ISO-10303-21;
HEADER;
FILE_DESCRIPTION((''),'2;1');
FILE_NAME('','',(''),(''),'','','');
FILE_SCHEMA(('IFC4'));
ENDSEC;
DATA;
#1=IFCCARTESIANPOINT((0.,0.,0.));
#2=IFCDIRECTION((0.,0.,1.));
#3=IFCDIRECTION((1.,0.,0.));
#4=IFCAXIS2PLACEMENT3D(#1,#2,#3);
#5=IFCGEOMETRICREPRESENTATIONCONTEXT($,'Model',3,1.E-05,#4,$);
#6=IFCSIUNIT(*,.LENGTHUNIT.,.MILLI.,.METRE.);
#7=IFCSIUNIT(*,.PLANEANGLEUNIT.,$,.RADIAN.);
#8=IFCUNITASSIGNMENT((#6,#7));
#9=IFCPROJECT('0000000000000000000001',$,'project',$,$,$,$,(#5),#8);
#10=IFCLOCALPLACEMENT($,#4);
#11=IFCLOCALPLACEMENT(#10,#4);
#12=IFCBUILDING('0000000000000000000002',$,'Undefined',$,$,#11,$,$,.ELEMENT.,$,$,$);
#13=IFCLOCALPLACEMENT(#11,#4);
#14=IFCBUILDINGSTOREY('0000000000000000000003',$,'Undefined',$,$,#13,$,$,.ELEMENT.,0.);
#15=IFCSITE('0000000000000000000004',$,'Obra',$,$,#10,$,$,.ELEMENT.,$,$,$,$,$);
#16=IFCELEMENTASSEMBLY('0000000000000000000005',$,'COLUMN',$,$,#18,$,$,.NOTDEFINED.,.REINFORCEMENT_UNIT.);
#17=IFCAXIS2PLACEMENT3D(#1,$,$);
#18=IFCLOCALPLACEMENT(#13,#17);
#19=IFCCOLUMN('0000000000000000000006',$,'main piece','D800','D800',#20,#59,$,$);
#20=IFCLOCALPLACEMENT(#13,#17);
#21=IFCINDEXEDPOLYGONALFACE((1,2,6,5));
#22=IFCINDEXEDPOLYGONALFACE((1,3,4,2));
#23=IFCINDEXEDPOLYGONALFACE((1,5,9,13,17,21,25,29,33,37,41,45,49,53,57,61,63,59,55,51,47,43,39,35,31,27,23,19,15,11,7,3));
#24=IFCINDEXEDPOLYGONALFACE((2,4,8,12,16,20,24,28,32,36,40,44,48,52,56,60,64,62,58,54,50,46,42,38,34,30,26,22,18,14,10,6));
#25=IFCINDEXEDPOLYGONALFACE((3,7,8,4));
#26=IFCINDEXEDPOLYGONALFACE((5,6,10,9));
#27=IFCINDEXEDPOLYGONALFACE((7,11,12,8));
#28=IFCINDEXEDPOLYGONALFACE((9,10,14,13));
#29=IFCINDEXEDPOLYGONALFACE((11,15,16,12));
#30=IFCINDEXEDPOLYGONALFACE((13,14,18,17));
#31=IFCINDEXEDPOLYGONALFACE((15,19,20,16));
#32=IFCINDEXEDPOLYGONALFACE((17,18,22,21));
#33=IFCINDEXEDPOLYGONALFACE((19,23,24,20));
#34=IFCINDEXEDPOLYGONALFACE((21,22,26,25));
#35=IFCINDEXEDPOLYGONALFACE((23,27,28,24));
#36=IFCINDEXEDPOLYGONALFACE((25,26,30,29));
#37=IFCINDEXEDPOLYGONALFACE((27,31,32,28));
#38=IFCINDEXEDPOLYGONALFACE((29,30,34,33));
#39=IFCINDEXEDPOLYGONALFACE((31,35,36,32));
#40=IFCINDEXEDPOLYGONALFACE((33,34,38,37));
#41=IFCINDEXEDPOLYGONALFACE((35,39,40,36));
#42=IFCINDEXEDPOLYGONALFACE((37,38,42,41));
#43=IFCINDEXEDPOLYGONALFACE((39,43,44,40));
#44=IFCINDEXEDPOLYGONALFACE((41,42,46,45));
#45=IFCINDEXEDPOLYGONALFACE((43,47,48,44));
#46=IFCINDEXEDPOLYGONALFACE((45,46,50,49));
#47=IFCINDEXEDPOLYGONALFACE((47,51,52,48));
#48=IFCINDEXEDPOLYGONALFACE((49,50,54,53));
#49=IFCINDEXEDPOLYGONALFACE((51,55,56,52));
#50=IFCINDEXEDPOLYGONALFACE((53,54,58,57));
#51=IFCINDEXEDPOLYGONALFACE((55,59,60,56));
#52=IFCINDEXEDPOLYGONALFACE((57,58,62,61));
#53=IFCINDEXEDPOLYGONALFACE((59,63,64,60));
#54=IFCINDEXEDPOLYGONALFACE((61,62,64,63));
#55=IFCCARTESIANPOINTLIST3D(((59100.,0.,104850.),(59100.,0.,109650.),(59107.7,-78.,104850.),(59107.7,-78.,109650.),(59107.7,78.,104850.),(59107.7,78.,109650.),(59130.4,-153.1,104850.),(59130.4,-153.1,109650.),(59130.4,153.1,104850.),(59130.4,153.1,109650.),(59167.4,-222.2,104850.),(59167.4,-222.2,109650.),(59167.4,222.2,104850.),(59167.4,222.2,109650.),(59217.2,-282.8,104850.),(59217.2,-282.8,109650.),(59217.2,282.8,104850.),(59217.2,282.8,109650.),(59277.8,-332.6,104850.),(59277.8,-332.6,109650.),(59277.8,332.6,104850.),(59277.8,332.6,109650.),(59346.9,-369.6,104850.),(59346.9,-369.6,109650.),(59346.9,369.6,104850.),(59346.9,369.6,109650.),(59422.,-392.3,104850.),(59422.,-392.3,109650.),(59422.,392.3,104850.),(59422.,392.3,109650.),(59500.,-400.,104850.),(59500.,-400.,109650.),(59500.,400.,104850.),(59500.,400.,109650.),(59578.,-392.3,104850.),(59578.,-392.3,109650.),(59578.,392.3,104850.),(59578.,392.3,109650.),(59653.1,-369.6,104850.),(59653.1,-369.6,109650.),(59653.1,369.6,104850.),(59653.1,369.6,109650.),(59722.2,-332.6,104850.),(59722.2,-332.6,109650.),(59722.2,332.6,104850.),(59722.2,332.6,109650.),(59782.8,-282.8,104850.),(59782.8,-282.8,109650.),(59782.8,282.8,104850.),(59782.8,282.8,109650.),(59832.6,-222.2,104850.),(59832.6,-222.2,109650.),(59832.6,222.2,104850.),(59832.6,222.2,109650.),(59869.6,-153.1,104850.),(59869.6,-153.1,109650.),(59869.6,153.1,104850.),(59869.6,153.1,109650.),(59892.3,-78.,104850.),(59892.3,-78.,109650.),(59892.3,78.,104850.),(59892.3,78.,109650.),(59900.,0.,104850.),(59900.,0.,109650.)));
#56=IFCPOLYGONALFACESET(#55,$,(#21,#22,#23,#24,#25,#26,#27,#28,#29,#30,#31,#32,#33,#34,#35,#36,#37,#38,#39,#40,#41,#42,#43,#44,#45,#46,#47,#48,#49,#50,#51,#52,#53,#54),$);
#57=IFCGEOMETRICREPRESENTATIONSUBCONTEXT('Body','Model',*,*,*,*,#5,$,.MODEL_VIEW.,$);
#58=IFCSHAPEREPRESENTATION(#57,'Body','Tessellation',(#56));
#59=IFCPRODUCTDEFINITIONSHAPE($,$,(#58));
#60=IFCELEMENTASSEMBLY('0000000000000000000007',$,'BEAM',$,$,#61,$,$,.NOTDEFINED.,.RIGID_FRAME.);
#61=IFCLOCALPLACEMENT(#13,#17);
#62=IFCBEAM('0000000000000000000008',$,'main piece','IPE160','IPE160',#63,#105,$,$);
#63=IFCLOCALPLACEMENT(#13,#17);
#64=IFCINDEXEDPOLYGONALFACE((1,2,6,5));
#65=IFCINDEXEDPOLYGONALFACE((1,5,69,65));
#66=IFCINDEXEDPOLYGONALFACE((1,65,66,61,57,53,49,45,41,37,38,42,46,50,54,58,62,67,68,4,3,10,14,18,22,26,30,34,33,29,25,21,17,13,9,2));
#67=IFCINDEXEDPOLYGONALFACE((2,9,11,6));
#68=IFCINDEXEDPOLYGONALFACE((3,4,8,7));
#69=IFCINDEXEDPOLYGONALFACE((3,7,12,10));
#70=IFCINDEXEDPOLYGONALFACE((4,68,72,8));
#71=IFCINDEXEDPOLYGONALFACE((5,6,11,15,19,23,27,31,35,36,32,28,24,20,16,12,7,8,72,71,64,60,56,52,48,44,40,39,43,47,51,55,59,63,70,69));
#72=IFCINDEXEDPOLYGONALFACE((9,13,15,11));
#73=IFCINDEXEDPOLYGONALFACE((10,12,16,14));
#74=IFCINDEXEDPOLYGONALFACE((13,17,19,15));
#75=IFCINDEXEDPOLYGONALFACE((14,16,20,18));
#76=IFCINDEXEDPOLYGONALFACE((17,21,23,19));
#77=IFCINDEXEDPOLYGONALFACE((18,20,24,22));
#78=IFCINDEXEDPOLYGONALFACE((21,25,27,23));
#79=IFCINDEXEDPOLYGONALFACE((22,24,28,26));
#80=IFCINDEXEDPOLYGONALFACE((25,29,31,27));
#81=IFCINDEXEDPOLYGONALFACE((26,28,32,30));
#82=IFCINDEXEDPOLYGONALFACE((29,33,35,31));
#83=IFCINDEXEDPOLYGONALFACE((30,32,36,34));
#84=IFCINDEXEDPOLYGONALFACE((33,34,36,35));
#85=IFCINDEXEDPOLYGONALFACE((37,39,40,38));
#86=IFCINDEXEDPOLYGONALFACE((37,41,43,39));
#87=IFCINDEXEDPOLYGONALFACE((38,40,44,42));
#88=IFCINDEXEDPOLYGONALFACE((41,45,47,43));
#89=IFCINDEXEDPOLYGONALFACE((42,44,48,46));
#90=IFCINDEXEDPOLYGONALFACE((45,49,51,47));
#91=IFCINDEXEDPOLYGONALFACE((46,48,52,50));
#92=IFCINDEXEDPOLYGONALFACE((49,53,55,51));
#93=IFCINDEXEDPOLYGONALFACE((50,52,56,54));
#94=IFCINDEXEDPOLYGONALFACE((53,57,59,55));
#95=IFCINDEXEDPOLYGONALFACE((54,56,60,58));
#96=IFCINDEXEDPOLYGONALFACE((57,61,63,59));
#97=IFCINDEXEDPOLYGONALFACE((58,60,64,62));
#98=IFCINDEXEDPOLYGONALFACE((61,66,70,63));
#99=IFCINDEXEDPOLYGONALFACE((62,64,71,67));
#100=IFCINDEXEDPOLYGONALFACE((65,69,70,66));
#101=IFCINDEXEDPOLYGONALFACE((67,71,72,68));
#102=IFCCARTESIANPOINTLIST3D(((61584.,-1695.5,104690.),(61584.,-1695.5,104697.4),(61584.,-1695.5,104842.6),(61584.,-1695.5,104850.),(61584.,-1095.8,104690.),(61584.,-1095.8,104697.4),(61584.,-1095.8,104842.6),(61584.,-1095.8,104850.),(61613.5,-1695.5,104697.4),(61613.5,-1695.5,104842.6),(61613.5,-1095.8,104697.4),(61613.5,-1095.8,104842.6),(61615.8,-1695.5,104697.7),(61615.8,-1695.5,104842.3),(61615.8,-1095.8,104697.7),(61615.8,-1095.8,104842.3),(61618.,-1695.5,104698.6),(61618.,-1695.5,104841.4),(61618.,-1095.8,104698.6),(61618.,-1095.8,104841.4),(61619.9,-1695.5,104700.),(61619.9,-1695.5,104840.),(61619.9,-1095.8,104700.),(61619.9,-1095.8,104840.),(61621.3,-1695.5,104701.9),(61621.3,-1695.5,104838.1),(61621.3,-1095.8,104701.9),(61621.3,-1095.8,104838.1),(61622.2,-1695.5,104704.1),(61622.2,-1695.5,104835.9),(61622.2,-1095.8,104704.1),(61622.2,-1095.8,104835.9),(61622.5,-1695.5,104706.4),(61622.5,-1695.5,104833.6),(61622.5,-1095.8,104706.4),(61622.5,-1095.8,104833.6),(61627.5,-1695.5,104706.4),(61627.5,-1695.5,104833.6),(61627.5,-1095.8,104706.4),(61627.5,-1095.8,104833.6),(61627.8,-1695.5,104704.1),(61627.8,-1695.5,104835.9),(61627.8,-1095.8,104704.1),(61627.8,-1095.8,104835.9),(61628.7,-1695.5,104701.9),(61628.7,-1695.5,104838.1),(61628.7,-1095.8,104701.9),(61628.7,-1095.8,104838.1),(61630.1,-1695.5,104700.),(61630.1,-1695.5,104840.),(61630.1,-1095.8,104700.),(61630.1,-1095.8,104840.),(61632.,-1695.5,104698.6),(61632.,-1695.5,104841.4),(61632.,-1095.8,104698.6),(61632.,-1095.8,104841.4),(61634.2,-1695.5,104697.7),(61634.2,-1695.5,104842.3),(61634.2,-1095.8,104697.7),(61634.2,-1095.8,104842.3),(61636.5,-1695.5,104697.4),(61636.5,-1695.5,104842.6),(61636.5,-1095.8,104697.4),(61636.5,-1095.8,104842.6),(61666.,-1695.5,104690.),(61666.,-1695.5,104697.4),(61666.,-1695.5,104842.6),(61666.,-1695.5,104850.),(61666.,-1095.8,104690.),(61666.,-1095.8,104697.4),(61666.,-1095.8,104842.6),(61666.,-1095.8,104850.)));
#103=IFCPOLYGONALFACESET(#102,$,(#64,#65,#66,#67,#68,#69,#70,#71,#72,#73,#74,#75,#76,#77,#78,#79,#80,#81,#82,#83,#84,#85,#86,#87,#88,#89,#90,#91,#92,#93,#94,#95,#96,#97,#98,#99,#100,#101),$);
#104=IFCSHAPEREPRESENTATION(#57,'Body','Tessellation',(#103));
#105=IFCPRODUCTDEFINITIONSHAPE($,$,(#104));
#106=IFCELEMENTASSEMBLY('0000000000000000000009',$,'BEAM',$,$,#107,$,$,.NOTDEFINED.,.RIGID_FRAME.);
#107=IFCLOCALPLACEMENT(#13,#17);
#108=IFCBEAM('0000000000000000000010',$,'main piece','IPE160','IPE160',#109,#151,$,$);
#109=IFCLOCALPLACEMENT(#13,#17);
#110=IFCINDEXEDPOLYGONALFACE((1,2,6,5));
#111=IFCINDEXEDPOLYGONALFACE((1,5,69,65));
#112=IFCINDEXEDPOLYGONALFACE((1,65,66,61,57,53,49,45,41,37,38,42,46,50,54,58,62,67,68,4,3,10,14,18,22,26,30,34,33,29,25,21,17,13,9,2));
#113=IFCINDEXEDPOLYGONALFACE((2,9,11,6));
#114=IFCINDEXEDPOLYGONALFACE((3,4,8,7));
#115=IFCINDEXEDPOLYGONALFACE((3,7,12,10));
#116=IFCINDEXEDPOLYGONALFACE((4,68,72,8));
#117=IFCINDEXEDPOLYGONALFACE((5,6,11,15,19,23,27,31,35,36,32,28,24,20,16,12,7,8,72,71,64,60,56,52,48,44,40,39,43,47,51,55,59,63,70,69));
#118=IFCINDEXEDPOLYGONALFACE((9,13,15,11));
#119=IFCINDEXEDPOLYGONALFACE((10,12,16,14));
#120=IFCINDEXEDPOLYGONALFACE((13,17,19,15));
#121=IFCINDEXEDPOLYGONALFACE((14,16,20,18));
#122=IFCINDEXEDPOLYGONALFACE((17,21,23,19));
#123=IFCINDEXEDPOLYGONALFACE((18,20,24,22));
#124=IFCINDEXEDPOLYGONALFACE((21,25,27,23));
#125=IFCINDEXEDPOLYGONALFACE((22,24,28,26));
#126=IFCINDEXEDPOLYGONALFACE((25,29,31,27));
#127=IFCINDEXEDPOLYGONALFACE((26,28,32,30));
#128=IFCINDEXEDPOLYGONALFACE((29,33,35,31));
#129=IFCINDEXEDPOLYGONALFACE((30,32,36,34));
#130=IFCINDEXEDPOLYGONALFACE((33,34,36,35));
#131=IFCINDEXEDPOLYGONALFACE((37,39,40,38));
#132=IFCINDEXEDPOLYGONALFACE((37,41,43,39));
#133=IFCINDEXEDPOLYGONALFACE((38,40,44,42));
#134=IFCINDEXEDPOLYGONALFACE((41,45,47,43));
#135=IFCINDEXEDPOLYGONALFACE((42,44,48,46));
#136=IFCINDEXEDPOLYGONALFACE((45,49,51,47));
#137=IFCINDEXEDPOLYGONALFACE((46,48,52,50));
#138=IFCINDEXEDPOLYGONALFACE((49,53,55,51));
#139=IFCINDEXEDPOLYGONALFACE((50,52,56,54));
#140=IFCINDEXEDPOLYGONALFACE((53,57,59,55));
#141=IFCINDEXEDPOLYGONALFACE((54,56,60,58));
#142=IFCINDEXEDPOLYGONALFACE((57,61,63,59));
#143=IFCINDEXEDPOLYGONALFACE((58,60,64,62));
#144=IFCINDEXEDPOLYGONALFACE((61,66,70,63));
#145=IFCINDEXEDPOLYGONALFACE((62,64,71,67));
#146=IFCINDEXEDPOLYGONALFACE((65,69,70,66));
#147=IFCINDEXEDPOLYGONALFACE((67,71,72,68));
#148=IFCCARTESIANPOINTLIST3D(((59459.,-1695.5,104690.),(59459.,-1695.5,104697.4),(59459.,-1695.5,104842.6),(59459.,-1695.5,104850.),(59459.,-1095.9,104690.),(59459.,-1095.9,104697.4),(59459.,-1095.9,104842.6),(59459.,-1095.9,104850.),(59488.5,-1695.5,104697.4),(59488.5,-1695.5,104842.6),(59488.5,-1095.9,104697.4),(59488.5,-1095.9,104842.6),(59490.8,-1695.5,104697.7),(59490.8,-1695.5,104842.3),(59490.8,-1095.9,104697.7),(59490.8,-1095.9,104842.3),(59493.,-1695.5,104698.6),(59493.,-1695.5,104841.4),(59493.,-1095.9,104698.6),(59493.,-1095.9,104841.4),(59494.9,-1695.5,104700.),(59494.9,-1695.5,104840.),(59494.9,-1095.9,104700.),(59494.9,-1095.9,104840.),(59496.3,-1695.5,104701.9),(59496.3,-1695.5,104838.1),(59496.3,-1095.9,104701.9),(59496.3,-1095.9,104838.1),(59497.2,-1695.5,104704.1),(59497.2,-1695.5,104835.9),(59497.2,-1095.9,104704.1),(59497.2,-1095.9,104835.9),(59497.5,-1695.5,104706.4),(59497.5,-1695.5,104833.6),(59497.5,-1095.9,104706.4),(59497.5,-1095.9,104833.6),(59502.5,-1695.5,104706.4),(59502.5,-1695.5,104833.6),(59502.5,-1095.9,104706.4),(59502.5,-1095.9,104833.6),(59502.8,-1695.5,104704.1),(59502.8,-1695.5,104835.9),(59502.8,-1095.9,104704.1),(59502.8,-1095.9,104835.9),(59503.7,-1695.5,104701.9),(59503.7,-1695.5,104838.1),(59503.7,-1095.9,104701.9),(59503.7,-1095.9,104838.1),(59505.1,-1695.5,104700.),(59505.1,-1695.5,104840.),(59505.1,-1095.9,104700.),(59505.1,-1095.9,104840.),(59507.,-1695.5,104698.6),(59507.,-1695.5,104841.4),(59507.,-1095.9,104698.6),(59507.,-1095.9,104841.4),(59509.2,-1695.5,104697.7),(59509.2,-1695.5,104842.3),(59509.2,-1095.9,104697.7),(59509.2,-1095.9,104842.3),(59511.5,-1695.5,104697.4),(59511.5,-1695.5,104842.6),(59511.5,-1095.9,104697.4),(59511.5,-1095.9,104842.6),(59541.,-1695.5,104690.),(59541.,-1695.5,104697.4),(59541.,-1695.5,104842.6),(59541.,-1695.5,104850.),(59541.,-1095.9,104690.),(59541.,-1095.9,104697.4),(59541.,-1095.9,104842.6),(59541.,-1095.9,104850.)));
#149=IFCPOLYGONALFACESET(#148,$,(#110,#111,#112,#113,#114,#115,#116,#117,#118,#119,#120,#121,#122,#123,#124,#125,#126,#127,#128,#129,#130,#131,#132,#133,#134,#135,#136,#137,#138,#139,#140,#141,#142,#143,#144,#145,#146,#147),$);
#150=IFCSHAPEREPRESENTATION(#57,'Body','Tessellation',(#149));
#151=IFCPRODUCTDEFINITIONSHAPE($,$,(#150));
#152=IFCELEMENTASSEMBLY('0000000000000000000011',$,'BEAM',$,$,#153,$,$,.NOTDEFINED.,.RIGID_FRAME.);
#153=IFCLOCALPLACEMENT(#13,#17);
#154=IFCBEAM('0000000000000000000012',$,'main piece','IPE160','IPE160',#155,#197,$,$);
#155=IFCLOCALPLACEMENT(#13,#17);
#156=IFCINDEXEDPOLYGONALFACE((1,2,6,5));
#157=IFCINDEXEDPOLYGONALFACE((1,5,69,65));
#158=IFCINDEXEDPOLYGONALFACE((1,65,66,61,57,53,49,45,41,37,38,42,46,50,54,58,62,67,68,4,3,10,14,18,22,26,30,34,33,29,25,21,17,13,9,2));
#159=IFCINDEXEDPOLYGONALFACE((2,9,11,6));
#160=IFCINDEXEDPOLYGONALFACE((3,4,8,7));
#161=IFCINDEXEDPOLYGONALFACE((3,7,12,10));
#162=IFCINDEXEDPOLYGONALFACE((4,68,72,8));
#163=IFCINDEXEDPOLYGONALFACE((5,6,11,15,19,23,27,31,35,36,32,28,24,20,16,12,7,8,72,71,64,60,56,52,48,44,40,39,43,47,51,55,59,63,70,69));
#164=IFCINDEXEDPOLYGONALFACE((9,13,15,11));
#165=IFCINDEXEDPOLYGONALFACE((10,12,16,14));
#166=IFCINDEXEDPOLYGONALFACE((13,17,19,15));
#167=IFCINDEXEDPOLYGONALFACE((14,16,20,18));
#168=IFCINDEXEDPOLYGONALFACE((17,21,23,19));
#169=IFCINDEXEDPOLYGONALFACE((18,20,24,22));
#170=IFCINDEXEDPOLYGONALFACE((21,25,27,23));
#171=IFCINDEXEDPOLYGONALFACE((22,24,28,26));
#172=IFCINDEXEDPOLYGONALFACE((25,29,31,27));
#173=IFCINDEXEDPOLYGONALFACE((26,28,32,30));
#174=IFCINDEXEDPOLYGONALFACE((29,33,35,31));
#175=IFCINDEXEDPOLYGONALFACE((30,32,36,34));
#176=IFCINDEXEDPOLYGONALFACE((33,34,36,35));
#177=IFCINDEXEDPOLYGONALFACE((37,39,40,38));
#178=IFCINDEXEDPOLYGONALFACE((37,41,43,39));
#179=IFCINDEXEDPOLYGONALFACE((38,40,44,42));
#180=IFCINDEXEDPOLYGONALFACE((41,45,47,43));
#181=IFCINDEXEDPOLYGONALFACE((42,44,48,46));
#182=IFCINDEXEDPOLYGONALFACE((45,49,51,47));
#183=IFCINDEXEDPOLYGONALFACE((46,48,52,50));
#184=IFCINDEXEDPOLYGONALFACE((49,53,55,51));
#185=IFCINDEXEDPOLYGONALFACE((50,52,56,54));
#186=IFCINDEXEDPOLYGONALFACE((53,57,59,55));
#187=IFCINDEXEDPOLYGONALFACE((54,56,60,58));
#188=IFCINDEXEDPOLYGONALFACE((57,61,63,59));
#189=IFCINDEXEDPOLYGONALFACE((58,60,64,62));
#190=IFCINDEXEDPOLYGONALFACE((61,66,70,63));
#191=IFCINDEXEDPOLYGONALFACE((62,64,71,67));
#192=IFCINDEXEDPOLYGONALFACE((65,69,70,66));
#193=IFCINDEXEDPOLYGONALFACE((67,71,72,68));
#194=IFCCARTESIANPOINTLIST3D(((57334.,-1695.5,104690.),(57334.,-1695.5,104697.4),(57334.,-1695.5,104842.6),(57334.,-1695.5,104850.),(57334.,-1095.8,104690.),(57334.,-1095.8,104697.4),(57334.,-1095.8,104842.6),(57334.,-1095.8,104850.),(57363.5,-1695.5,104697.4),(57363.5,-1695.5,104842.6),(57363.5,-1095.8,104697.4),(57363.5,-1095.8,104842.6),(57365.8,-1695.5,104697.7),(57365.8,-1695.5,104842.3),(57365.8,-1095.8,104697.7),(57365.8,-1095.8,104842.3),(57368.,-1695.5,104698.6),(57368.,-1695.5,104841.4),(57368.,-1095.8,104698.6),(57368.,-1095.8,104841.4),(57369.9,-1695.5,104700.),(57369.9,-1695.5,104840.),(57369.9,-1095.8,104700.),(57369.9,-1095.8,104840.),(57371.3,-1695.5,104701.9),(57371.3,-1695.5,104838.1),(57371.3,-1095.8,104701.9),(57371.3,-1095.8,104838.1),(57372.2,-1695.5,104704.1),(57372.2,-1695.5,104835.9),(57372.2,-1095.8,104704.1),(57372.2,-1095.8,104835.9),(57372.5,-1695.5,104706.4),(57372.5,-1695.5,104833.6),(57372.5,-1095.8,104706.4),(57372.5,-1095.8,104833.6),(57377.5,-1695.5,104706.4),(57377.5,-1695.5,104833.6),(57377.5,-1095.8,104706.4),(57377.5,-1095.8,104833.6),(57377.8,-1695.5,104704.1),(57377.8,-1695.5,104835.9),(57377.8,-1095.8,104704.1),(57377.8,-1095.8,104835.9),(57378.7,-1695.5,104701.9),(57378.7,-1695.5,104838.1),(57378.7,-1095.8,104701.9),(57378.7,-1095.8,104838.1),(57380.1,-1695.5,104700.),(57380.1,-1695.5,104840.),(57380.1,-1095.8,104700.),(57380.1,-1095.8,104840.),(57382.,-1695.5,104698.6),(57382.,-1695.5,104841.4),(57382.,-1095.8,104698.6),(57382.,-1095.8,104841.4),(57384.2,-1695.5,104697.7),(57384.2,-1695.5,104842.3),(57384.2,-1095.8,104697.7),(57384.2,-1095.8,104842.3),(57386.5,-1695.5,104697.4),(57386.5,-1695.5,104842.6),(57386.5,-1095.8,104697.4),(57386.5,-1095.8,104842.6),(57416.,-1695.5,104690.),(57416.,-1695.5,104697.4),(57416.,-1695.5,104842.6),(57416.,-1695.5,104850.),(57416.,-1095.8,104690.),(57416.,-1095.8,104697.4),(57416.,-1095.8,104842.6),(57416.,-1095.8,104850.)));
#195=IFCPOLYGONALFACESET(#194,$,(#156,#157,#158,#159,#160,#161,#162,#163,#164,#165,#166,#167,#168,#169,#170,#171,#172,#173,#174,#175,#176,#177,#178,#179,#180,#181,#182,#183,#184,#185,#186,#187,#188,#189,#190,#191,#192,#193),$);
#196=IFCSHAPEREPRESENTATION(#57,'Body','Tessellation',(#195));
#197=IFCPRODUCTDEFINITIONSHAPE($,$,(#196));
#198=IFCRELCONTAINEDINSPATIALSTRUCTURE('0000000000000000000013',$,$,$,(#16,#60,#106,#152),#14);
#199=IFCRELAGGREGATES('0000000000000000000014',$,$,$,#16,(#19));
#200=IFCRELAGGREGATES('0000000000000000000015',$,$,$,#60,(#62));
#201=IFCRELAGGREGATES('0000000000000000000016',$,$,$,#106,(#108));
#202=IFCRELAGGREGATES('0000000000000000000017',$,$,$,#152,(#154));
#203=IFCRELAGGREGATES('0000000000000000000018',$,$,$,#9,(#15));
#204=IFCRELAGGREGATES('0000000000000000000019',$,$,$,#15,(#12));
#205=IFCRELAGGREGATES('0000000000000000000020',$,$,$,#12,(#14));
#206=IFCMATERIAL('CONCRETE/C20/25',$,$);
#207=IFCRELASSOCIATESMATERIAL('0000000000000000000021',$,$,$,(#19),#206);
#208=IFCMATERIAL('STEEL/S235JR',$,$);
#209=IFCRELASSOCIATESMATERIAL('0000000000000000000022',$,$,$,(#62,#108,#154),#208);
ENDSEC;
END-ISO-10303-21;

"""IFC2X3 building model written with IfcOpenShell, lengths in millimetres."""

from ifc_helpers import new_model, si_unit, frame, origin_with_axes, origin_2d_with_axis, place, context, subcontext, project, spatial, circle, i_section, extrude, material, element, aggregate, save


model = new_model("IFC2X3")

# Units and contexts
model_context = context("Model", 3, precision=1e-05, world=origin_with_axes())
body_context = subcontext(model_context, "Body", "Model", "MODEL_VIEW")
ifc_project = project(units=[si_unit("LENGTHUNIT", "METRE", prefix="MILLI"), si_unit("PLANEANGLEUNIT", "RADIAN")], contexts=[model_context])

# Site, building, storey
site_placement = place(None, origin_with_axes())
site = spatial("IfcSite", under=ifc_project, at=site_placement, Name="Obra", CompositionType="ELEMENT")
building_placement = place(site_placement, origin_with_axes())
building = spatial("IfcBuilding", under=site, at=building_placement, Name="Undefined", CompositionType="ELEMENT")
storey_placement = place(building_placement, origin_with_axes())
storey = spatial("IfcBuildingStorey", under=building, at=storey_placement, Name="Undefined", CompositionType="ELEMENT", Elevation=0.0)

# Element assembly, column
assembly_1_placement = place(storey_placement, origin_with_axes())
assembly_1 = element("IfcElementAssembly", 1, at=assembly_1_placement, inside=storey, Name="COLUMN", AssemblyPlace="NOTDEFINED", PredefinedType="REINFORCEMENT_UNIT")
ifc_material_1 = material(Name="CONCRETE/C20/25")
column_placement = place(assembly_1_placement, frame((59500.0, 0.0, 104850.0), z_axis=(0.0, 0.0, 1.0), x_axis=(0.0, 1.0, 0.0)))
column = element("IfcColumn", 2, at=column_placement, material=ifc_material_1, Name="main piece", Description="D800", ObjectType="D800", context=body_context, shape_type="SweptSolid", body=[
    extrude(circle(Radius=400.0, at=origin_2d_with_axis()), frame((0.0, 0.0, 4800.0), z_axis=(0.0, 0.0, -1.0), x_axis=(0.0, 1.0, 0.0)), (0.0, 0.0, 1.0), 4800.0),
])
aggregate(assembly_1, [column])

# Element assemblies, beams
assembly_2_placement = place(storey_placement, origin_with_axes())
assembly_2 = element("IfcElementAssembly", 3, at=assembly_2_placement, inside=storey, Name="BEAM", AssemblyPlace="NOTDEFINED", PredefinedType="RIGID_FRAME")
ifc_material_2 = material(Name="STEEL/S235JR")
beam_1_placement = place(assembly_2_placement, frame((61625.0, -1095.8, 104770.0), z_axis=(0.0, 0.0, 1.0), x_axis=(0.0, -1.0, 0.0)))
beam_1 = element("IfcBeam", 4, at=beam_1_placement, material=ifc_material_2, Name="main piece", Description="IPE160", ObjectType="IPE160", context=body_context, shape_type="SweptSolid", body=[
    extrude(i_section(OverallWidth=82.0, OverallDepth=160.0, WebThickness=5.0, FlangeThickness=7.4, FilletRadius=9.0, at=origin_2d_with_axis()), frame((599.7, 0.0, 0.0), z_axis=(-1.0, 0.0, 0.0), x_axis=(0.0, -1.0, 0.0)), (0.0, 0.0, 1.0), 599.7),
])
aggregate(assembly_2, [beam_1])
assembly_3_placement = place(storey_placement, origin_with_axes())
assembly_3 = element("IfcElementAssembly", 5, at=assembly_3_placement, inside=storey, Name="BEAM", AssemblyPlace="NOTDEFINED", PredefinedType="RIGID_FRAME")
beam_2_placement = place(assembly_3_placement, frame((59500.0, -1095.9, 104770.0), z_axis=(0.0, 0.0, 1.0), x_axis=(0.0, -1.0, 0.0)))
beam_2 = element("IfcBeam", 6, at=beam_2_placement, material=ifc_material_2, Name="main piece", Description="IPE160", ObjectType="IPE160", context=body_context, shape_type="SweptSolid", body=[
    extrude(i_section(OverallWidth=82.0, OverallDepth=160.0, WebThickness=5.0, FlangeThickness=7.4, FilletRadius=9.0, at=origin_2d_with_axis()), frame((599.6, 0.0, 0.0), z_axis=(-1.0, 0.0, 0.0), x_axis=(0.0, -1.0, 0.0)), (0.0, 0.0, 1.0), 599.6),
])
aggregate(assembly_3, [beam_2])
assembly_4_placement = place(storey_placement, origin_with_axes())
assembly_4 = element("IfcElementAssembly", 7, at=assembly_4_placement, inside=storey, Name="BEAM", AssemblyPlace="NOTDEFINED", PredefinedType="RIGID_FRAME")
beam_3_placement = place(assembly_4_placement, frame((57375.0, -1095.8, 104770.0), z_axis=(0.0, 0.0, 1.0), x_axis=(0.0, -1.0, 0.0)))
beam_3 = element("IfcBeam", 8, at=beam_3_placement, material=ifc_material_2, Name="main piece", Description="IPE160", ObjectType="IPE160", context=body_context, shape_type="SweptSolid", body=[
    extrude(i_section(OverallWidth=82.0, OverallDepth=160.0, WebThickness=5.0, FlangeThickness=7.4, FilletRadius=9.0, at=origin_2d_with_axis()), frame((599.7, 0.0, 0.0), z_axis=(-1.0, 0.0, 0.0), x_axis=(0.0, -1.0, 0.0)), (0.0, 0.0, 1.0), 599.7),
])
aggregate(assembly_4, [beam_3])

save(model, "model.ifc")
